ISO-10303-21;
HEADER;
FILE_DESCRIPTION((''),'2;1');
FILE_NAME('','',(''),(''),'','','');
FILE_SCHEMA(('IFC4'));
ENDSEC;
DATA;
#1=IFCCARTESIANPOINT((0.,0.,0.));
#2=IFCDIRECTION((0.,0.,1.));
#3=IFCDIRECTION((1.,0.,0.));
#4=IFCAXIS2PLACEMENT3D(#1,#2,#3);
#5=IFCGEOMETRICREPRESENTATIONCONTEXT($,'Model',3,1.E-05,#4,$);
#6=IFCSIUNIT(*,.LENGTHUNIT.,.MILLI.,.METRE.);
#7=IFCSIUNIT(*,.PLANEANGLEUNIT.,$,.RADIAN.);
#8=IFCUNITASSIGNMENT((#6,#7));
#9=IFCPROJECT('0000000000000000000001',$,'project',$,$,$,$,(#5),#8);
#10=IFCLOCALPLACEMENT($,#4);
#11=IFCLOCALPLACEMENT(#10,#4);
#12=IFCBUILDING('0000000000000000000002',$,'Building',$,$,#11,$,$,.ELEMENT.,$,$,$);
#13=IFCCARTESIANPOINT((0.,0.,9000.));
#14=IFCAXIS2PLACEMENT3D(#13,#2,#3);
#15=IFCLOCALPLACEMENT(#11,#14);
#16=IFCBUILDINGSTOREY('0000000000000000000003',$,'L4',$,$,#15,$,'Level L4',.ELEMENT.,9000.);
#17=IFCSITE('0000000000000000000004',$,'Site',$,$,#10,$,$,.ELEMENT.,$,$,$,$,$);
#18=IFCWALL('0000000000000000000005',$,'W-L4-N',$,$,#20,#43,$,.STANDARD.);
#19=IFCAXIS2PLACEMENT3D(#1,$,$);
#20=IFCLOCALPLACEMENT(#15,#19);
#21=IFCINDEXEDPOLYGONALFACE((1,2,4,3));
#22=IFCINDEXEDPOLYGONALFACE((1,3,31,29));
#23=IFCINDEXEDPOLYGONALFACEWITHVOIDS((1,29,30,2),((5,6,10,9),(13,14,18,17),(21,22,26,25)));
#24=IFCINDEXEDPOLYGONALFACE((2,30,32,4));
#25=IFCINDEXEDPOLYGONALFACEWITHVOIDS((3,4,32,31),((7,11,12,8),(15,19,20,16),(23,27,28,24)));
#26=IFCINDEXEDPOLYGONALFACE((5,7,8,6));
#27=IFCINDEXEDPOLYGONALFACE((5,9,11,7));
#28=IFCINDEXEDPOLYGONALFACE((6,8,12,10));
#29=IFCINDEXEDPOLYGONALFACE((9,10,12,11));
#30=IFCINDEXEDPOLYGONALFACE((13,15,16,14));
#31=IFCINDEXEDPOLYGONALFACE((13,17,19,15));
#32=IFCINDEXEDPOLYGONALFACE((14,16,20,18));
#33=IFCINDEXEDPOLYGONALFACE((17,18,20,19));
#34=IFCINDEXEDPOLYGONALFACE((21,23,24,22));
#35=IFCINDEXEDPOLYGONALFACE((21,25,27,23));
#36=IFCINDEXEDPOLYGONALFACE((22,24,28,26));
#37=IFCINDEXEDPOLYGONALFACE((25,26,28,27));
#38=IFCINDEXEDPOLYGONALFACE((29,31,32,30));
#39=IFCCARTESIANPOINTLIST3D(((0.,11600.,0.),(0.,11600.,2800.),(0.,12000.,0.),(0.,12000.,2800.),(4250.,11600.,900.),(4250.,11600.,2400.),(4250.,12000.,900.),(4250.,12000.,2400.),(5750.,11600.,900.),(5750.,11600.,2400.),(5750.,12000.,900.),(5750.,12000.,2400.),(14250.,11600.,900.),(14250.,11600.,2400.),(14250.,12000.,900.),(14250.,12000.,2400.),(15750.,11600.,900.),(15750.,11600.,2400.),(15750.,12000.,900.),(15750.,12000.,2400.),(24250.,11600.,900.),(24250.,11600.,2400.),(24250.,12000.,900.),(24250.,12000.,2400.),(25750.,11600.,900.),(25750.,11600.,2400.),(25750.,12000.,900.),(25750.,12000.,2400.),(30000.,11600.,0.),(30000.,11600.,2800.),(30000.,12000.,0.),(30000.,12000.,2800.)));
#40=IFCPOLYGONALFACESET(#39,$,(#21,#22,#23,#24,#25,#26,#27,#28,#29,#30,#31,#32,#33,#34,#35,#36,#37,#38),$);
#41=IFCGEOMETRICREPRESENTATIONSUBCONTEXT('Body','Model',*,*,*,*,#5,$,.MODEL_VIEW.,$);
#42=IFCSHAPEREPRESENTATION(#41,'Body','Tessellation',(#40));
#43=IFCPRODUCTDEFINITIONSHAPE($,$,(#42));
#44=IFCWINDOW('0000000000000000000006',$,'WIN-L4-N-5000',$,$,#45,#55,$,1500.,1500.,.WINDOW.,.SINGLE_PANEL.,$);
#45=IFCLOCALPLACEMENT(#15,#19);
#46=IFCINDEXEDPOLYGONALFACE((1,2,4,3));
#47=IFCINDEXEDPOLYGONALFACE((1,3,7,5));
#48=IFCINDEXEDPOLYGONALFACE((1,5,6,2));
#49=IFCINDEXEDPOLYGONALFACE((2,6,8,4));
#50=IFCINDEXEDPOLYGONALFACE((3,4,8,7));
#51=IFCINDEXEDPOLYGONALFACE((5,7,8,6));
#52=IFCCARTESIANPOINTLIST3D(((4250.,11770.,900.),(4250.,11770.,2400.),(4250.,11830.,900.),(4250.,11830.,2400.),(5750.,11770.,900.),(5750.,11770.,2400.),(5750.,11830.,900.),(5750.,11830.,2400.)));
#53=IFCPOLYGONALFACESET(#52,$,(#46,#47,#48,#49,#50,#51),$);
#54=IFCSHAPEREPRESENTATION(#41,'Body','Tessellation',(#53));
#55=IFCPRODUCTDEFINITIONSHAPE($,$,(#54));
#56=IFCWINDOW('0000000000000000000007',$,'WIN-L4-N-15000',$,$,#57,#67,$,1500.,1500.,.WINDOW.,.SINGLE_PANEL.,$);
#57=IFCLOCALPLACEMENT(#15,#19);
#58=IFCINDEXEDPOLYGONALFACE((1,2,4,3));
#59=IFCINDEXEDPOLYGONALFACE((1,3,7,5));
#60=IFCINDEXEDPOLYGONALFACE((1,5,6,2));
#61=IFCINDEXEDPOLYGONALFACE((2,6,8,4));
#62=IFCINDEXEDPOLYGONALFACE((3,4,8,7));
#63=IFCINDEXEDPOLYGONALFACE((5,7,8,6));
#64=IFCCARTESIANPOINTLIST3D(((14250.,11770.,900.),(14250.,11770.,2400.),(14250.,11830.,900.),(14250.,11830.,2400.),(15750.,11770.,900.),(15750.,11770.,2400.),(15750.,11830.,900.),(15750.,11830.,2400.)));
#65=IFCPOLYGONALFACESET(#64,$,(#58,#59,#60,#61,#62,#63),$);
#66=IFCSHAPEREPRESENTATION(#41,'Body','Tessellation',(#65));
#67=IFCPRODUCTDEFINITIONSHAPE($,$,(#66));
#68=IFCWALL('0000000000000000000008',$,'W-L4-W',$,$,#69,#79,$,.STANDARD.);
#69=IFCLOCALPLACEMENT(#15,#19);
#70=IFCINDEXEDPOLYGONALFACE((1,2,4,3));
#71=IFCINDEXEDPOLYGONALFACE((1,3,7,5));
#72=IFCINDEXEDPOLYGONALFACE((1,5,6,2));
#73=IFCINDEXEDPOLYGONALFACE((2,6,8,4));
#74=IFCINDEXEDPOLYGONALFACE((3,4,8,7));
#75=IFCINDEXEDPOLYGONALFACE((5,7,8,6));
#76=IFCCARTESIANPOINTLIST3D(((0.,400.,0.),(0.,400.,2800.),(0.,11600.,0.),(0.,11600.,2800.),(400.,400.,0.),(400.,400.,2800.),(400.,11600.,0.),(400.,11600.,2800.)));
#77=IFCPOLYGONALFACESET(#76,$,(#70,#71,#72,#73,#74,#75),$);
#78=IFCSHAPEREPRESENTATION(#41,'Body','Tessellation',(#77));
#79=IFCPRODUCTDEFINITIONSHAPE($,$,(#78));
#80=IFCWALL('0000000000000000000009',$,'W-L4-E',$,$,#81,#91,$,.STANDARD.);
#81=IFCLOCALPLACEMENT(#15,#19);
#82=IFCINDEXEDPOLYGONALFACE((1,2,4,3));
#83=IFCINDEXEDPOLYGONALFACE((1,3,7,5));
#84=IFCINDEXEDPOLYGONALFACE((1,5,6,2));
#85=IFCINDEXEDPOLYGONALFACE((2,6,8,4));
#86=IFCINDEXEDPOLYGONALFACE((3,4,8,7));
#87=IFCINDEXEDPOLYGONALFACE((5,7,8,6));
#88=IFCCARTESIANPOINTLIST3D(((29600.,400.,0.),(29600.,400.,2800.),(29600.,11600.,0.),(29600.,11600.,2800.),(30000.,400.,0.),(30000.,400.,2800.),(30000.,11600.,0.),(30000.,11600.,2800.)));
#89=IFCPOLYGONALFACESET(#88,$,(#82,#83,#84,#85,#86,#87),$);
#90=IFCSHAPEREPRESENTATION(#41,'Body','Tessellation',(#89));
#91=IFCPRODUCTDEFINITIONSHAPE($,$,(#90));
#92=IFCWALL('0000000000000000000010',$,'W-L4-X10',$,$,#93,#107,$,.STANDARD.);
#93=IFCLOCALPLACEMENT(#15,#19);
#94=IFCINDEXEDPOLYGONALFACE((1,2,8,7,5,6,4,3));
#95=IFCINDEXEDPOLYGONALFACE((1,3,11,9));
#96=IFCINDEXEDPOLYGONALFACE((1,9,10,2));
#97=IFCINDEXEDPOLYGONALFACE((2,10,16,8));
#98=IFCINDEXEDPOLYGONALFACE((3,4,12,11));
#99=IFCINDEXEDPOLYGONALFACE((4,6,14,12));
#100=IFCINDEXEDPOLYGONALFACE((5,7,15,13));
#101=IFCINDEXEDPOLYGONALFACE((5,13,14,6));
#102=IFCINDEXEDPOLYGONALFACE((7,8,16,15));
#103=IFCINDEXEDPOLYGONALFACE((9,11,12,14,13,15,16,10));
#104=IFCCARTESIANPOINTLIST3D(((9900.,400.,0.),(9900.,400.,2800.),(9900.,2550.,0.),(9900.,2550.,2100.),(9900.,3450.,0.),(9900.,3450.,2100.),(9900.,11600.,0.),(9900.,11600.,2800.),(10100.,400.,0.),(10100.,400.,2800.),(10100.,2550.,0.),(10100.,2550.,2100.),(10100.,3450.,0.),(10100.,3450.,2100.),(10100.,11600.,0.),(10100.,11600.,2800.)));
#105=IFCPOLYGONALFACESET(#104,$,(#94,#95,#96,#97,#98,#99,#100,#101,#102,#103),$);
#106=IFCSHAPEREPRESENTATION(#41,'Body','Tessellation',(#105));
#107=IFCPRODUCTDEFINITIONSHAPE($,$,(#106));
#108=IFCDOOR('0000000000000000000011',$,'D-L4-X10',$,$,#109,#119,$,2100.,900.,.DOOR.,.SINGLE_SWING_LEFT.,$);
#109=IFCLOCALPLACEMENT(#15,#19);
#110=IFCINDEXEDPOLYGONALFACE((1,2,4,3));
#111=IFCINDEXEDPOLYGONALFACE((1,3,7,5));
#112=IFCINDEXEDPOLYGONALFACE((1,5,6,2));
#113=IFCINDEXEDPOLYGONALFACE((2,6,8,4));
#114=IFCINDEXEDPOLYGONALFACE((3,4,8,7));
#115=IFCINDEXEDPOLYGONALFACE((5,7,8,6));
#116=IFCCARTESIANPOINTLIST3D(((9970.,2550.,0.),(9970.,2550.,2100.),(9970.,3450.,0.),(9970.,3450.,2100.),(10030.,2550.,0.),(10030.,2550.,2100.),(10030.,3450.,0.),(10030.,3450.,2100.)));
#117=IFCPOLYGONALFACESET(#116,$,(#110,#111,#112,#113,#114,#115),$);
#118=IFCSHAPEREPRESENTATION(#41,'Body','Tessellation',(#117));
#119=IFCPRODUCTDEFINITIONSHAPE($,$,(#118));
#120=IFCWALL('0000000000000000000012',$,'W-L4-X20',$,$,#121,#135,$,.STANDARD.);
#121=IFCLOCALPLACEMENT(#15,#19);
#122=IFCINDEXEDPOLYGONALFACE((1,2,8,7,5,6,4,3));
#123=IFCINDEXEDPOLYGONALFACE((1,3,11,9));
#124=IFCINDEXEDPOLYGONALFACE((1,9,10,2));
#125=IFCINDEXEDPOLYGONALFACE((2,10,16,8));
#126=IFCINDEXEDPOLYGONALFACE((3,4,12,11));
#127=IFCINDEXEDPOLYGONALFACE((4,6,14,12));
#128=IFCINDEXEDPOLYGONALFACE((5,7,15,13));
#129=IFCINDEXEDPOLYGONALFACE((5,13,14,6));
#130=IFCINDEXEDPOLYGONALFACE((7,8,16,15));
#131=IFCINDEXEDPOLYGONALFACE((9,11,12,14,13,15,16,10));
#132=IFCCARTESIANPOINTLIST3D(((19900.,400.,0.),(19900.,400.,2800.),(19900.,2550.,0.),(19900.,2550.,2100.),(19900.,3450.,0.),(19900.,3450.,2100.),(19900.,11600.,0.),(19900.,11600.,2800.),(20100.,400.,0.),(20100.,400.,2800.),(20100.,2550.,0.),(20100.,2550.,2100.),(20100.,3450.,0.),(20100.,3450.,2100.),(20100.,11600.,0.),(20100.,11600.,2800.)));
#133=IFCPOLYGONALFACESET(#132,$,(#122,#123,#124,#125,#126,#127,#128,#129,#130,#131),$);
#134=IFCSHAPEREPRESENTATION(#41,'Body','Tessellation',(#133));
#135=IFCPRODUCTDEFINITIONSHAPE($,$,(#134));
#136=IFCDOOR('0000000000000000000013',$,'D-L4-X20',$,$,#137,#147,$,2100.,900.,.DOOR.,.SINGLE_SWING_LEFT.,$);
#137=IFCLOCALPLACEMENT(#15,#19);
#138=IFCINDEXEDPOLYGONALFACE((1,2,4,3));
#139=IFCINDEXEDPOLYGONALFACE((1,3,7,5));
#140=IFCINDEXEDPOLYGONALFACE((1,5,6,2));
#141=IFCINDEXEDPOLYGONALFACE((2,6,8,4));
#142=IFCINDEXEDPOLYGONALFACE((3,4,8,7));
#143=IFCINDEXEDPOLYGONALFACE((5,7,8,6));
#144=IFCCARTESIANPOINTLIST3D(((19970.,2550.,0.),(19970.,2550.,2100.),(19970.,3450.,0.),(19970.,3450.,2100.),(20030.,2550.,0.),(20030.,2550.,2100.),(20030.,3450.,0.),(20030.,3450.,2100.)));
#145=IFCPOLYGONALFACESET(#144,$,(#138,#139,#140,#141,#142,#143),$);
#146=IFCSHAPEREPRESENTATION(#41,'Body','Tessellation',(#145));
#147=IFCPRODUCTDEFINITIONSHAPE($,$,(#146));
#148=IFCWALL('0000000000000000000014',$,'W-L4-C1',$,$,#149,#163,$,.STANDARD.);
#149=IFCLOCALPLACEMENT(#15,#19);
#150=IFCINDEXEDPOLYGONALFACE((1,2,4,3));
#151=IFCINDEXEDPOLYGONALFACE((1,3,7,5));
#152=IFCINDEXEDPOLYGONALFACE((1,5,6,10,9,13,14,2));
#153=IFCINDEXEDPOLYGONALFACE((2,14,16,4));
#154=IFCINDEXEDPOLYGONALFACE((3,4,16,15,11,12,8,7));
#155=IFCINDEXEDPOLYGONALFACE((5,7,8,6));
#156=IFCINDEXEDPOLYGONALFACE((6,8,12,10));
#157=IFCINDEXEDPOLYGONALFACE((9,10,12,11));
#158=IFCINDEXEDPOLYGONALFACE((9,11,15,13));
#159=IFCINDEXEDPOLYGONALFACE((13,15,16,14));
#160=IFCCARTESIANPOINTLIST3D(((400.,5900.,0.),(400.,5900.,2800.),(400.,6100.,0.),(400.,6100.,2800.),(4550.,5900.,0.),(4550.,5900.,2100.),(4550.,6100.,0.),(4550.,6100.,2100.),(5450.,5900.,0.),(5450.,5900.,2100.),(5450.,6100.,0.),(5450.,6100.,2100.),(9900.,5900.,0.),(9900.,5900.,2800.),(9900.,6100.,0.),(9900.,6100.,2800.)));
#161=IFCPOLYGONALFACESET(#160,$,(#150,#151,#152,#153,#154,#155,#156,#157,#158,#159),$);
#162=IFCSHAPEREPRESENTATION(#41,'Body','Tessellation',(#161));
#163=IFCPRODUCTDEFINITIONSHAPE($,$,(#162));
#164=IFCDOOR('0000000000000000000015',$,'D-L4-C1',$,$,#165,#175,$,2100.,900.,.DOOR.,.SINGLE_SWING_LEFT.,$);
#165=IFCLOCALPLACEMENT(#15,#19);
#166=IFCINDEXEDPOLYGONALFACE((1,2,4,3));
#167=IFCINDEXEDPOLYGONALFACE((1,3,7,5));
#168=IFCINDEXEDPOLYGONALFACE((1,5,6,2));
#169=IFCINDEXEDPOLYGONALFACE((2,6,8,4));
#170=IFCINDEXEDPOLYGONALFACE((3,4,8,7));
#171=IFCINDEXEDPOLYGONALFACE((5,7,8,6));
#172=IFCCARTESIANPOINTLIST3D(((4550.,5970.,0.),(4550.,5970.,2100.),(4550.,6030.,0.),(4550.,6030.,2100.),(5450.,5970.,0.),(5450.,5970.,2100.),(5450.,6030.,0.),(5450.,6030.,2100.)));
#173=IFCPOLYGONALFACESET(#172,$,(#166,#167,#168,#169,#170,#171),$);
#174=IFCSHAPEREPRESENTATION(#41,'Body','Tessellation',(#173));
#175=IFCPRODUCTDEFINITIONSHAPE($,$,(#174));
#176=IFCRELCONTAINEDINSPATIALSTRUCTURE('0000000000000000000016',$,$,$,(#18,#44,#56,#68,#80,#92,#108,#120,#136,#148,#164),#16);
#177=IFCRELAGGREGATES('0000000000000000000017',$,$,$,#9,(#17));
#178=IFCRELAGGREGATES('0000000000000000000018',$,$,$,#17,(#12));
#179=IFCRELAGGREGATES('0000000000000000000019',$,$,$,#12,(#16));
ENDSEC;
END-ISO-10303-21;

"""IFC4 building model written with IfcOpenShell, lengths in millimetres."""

from ifc_helpers import new_model, si_unit, frame, origin_with_axes, origin_2d, place, context, subcontext, project, spatial, rectangle, extrude, element, fill, save


model = new_model("IFC4")

# Units and contexts
model_context = context("Model", 3, precision=1e-05, world=origin_with_axes())
body_context = subcontext(model_context, "Body", "Model", "MODEL_VIEW")
ifc_project = project(units=[si_unit("LENGTHUNIT", "METRE", prefix="MILLI"), si_unit("PLANEANGLEUNIT", "RADIAN")], contexts=[model_context])

# Site, building, storey
site_placement = place(None, origin_with_axes())
site = spatial("IfcSite", under=ifc_project, at=site_placement, Name="Site", CompositionType="ELEMENT")
building_placement = place(site_placement, origin_with_axes())
building = spatial("IfcBuilding", under=site, at=building_placement, Name="Building", CompositionType="ELEMENT")
storey_placement = place(building_placement, frame((0.0, 0.0, 9000.0), z_axis=(0.0, 0.0, 1.0), x_axis=(1.0, 0.0, 0.0)))
storey = spatial("IfcBuildingStorey", under=building, at=storey_placement, Name="L4", LongName="Level L4", CompositionType="ELEMENT", Elevation=9000.0)

# Wall, openings, windows
wall_1_placement = place(storey_placement, frame((15000.0, 11800.0, 0.0), z_axis=(0.0, 0.0, 1.0), x_axis=(1.0, 0.0, 0.0)))
wall_1 = element("IfcWall", 1, at=wall_1_placement, inside=storey, Name="W-L4-N", PredefinedType="STANDARD", context=body_context, shape_type="SweptSolid", body=[
    extrude(rectangle(XDim=30000.0, YDim=400.0, at=origin_2d()), origin_with_axes(), (0.0, 0.0, 1.0), 2800.0),
])
opening_1_placement = place(wall_1_placement, frame((-10000.0, 0.0, 900.0), z_axis=(0.0, 0.0, 1.0), x_axis=(1.0, 0.0, 0.0)))
opening_1 = element("IfcOpeningElement", 2, at=opening_1_placement, cuts=wall_1, PredefinedType="OPENING", context=body_context, shape_type="SweptSolid", body=[
    extrude(rectangle(XDim=1500.0, YDim=500.0, at=origin_2d()), origin_with_axes(), (0.0, 0.0, 1.0), 1500.0),
])
opening_2_placement = place(wall_1_placement, frame((0.0, 0.0, 900.0), z_axis=(0.0, 0.0, 1.0), x_axis=(1.0, 0.0, 0.0)))
opening_2 = element("IfcOpeningElement", 3, at=opening_2_placement, cuts=wall_1, PredefinedType="OPENING", context=body_context, shape_type="SweptSolid", body=[
    extrude(rectangle(XDim=1500.0, YDim=500.0, at=origin_2d()), origin_with_axes(), (0.0, 0.0, 1.0), 1500.0),
])
opening_3_placement = place(wall_1_placement, frame((10000.0, 0.0, 900.0), z_axis=(0.0, 0.0, 1.0), x_axis=(1.0, 0.0, 0.0)))
element("IfcOpeningElement", 4, at=opening_3_placement, cuts=wall_1, PredefinedType="OPENING", context=body_context, shape_type="SweptSolid", body=[
    extrude(rectangle(XDim=1500.0, YDim=500.0, at=origin_2d()), origin_with_axes(), (0.0, 0.0, 1.0), 1500.0),
])
window_1_placement = place(wall_1_placement, frame((-10000.0, 0.0, 900.0), z_axis=(0.0, 0.0, 1.0), x_axis=(1.0, 0.0, 0.0)))
window_1 = element("IfcWindow", 5, at=window_1_placement, inside=storey, Name="WIN-L4-N-5000", OverallHeight=1500.0, OverallWidth=1500.0, PartitioningType="SINGLE_PANEL", PredefinedType="WINDOW", context=body_context, shape_type="SweptSolid", body=[
    extrude(rectangle(XDim=1500.0, YDim=60.0, at=origin_2d()), origin_with_axes(), (0.0, 0.0, 1.0), 1500.0),
])
fill(opening_1, window_1)
window_2_placement = place(wall_1_placement, frame((0.0, 0.0, 900.0), z_axis=(0.0, 0.0, 1.0), x_axis=(1.0, 0.0, 0.0)))
window_2 = element("IfcWindow", 6, at=window_2_placement, inside=storey, Name="WIN-L4-N-15000", OverallHeight=1500.0, OverallWidth=1500.0, PartitioningType="SINGLE_PANEL", PredefinedType="WINDOW", context=body_context, shape_type="SweptSolid", body=[
    extrude(rectangle(XDim=1500.0, YDim=60.0, at=origin_2d()), origin_with_axes(), (0.0, 0.0, 1.0), 1500.0),
])
fill(opening_2, window_2)

# Walls
for number, where, z_axis, x_axis, name in (
    (7, (200.0, 6000.0, 0.0), (0.0, 0.0, 1.0), (1.0, 0.0, 0.0), "W-L4-W"),
    (8, (29800.0, 6000.0, 0.0), (0.0, 0.0, 1.0), (1.0, 0.0, 0.0), "W-L4-E"),
):
    element("IfcWall", number, at=place(storey_placement, frame(where, z_axis=z_axis, x_axis=x_axis)), inside=storey, Name=name, PredefinedType="STANDARD", context=body_context, shape_type="SweptSolid", body=[
        extrude(rectangle(XDim=400.0, YDim=11200.0, at=origin_2d()), origin_with_axes(), (0.0, 0.0, 1.0), 2800.0),
    ])

# Walls, openings, doors
wall_2_placement = place(storey_placement, frame((10000.0, 6000.0, 0.0), z_axis=(0.0, 0.0, 1.0), x_axis=(1.0, 0.0, 0.0)))
wall_2 = element("IfcWall", 9, at=wall_2_placement, inside=storey, Name="W-L4-X10", PredefinedType="STANDARD", context=body_context, shape_type="SweptSolid", body=[
    extrude(rectangle(XDim=200.0, YDim=11200.0, at=origin_2d()), origin_with_axes(), (0.0, 0.0, 1.0), 2800.0),
])
opening_4_placement = place(wall_2_placement, frame((0.0, -3000.0, 0.0), z_axis=(0.0, 0.0, 1.0), x_axis=(1.0, 0.0, 0.0)))
opening_4 = element("IfcOpeningElement", 10, at=opening_4_placement, cuts=wall_2, PredefinedType="OPENING", context=body_context, shape_type="SweptSolid", body=[
    extrude(rectangle(XDim=300.0, YDim=900.0, at=origin_2d()), origin_with_axes(), (0.0, 0.0, 1.0), 2100.0),
])
door_1_placement = place(wall_2_placement, frame((0.0, -3000.0, 0.0), z_axis=(0.0, 0.0, 1.0), x_axis=(1.0, 0.0, 0.0)))
door_1 = element("IfcDoor", 11, at=door_1_placement, inside=storey, Name="D-L4-X10", OperationType="SINGLE_SWING_LEFT", OverallHeight=2100.0, OverallWidth=900.0, PredefinedType="DOOR", context=body_context, shape_type="SweptSolid", body=[
    extrude(rectangle(XDim=60.0, YDim=900.0, at=origin_2d()), origin_with_axes(), (0.0, 0.0, 1.0), 2100.0),
])
fill(opening_4, door_1)
wall_3_placement = place(storey_placement, frame((20000.0, 6000.0, 0.0), z_axis=(0.0, 0.0, 1.0), x_axis=(1.0, 0.0, 0.0)))
wall_3 = element("IfcWall", 12, at=wall_3_placement, inside=storey, Name="W-L4-X20", PredefinedType="STANDARD", context=body_context, shape_type="SweptSolid", body=[
    extrude(rectangle(XDim=200.0, YDim=11200.0, at=origin_2d()), origin_with_axes(), (0.0, 0.0, 1.0), 2800.0),
])
opening_5_placement = place(wall_3_placement, frame((0.0, -3000.0, 0.0), z_axis=(0.0, 0.0, 1.0), x_axis=(1.0, 0.0, 0.0)))
opening_5 = element("IfcOpeningElement", 13, at=opening_5_placement, cuts=wall_3, PredefinedType="OPENING", context=body_context, shape_type="SweptSolid", body=[
    extrude(rectangle(XDim=300.0, YDim=900.0, at=origin_2d()), origin_with_axes(), (0.0, 0.0, 1.0), 2100.0),
])
door_2_placement = place(wall_3_placement, frame((0.0, -3000.0, 0.0), z_axis=(0.0, 0.0, 1.0), x_axis=(1.0, 0.0, 0.0)))
door_2 = element("IfcDoor", 14, at=door_2_placement, inside=storey, Name="D-L4-X20", OperationType="SINGLE_SWING_LEFT", OverallHeight=2100.0, OverallWidth=900.0, PredefinedType="DOOR", context=body_context, shape_type="SweptSolid", body=[
    extrude(rectangle(XDim=60.0, YDim=900.0, at=origin_2d()), origin_with_axes(), (0.0, 0.0, 1.0), 2100.0),
])
fill(opening_5, door_2)
wall_4_placement = place(storey_placement, frame((5150.0, 6000.0, 0.0), z_axis=(0.0, 0.0, 1.0), x_axis=(1.0, 0.0, 0.0)))
wall_4 = element("IfcWall", 15, at=wall_4_placement, inside=storey, Name="W-L4-C1", PredefinedType="STANDARD", context=body_context, shape_type="SweptSolid", body=[
    extrude(rectangle(XDim=9500.0, YDim=200.0, at=origin_2d()), origin_with_axes(), (0.0, 0.0, 1.0), 2800.0),
])
opening_6_placement = place(wall_4_placement, frame((-150.0, 0.0, 0.0), z_axis=(0.0, 0.0, 1.0), x_axis=(1.0, 0.0, 0.0)))
opening_6 = element("IfcOpeningElement", 16, at=opening_6_placement, cuts=wall_4, PredefinedType="OPENING", context=body_context, shape_type="SweptSolid", body=[
    extrude(rectangle(XDim=900.0, YDim=300.0, at=origin_2d()), origin_with_axes(), (0.0, 0.0, 1.0), 2100.0),
])
door_3_placement = place(wall_4_placement, frame((-150.0, 0.0, 0.0), z_axis=(0.0, 0.0, 1.0), x_axis=(1.0, 0.0, 0.0)))
door_3 = element("IfcDoor", 17, at=door_3_placement, inside=storey, Name="D-L4-C1", OperationType="SINGLE_SWING_LEFT", OverallHeight=2100.0, OverallWidth=900.0, PredefinedType="DOOR", context=body_context, shape_type="SweptSolid", body=[
    extrude(rectangle(XDim=900.0, YDim=60.0, at=origin_2d()), origin_with_axes(), (0.0, 0.0, 1.0), 2100.0),
])
fill(opening_6, door_3)

save(model, "model.ifc")
